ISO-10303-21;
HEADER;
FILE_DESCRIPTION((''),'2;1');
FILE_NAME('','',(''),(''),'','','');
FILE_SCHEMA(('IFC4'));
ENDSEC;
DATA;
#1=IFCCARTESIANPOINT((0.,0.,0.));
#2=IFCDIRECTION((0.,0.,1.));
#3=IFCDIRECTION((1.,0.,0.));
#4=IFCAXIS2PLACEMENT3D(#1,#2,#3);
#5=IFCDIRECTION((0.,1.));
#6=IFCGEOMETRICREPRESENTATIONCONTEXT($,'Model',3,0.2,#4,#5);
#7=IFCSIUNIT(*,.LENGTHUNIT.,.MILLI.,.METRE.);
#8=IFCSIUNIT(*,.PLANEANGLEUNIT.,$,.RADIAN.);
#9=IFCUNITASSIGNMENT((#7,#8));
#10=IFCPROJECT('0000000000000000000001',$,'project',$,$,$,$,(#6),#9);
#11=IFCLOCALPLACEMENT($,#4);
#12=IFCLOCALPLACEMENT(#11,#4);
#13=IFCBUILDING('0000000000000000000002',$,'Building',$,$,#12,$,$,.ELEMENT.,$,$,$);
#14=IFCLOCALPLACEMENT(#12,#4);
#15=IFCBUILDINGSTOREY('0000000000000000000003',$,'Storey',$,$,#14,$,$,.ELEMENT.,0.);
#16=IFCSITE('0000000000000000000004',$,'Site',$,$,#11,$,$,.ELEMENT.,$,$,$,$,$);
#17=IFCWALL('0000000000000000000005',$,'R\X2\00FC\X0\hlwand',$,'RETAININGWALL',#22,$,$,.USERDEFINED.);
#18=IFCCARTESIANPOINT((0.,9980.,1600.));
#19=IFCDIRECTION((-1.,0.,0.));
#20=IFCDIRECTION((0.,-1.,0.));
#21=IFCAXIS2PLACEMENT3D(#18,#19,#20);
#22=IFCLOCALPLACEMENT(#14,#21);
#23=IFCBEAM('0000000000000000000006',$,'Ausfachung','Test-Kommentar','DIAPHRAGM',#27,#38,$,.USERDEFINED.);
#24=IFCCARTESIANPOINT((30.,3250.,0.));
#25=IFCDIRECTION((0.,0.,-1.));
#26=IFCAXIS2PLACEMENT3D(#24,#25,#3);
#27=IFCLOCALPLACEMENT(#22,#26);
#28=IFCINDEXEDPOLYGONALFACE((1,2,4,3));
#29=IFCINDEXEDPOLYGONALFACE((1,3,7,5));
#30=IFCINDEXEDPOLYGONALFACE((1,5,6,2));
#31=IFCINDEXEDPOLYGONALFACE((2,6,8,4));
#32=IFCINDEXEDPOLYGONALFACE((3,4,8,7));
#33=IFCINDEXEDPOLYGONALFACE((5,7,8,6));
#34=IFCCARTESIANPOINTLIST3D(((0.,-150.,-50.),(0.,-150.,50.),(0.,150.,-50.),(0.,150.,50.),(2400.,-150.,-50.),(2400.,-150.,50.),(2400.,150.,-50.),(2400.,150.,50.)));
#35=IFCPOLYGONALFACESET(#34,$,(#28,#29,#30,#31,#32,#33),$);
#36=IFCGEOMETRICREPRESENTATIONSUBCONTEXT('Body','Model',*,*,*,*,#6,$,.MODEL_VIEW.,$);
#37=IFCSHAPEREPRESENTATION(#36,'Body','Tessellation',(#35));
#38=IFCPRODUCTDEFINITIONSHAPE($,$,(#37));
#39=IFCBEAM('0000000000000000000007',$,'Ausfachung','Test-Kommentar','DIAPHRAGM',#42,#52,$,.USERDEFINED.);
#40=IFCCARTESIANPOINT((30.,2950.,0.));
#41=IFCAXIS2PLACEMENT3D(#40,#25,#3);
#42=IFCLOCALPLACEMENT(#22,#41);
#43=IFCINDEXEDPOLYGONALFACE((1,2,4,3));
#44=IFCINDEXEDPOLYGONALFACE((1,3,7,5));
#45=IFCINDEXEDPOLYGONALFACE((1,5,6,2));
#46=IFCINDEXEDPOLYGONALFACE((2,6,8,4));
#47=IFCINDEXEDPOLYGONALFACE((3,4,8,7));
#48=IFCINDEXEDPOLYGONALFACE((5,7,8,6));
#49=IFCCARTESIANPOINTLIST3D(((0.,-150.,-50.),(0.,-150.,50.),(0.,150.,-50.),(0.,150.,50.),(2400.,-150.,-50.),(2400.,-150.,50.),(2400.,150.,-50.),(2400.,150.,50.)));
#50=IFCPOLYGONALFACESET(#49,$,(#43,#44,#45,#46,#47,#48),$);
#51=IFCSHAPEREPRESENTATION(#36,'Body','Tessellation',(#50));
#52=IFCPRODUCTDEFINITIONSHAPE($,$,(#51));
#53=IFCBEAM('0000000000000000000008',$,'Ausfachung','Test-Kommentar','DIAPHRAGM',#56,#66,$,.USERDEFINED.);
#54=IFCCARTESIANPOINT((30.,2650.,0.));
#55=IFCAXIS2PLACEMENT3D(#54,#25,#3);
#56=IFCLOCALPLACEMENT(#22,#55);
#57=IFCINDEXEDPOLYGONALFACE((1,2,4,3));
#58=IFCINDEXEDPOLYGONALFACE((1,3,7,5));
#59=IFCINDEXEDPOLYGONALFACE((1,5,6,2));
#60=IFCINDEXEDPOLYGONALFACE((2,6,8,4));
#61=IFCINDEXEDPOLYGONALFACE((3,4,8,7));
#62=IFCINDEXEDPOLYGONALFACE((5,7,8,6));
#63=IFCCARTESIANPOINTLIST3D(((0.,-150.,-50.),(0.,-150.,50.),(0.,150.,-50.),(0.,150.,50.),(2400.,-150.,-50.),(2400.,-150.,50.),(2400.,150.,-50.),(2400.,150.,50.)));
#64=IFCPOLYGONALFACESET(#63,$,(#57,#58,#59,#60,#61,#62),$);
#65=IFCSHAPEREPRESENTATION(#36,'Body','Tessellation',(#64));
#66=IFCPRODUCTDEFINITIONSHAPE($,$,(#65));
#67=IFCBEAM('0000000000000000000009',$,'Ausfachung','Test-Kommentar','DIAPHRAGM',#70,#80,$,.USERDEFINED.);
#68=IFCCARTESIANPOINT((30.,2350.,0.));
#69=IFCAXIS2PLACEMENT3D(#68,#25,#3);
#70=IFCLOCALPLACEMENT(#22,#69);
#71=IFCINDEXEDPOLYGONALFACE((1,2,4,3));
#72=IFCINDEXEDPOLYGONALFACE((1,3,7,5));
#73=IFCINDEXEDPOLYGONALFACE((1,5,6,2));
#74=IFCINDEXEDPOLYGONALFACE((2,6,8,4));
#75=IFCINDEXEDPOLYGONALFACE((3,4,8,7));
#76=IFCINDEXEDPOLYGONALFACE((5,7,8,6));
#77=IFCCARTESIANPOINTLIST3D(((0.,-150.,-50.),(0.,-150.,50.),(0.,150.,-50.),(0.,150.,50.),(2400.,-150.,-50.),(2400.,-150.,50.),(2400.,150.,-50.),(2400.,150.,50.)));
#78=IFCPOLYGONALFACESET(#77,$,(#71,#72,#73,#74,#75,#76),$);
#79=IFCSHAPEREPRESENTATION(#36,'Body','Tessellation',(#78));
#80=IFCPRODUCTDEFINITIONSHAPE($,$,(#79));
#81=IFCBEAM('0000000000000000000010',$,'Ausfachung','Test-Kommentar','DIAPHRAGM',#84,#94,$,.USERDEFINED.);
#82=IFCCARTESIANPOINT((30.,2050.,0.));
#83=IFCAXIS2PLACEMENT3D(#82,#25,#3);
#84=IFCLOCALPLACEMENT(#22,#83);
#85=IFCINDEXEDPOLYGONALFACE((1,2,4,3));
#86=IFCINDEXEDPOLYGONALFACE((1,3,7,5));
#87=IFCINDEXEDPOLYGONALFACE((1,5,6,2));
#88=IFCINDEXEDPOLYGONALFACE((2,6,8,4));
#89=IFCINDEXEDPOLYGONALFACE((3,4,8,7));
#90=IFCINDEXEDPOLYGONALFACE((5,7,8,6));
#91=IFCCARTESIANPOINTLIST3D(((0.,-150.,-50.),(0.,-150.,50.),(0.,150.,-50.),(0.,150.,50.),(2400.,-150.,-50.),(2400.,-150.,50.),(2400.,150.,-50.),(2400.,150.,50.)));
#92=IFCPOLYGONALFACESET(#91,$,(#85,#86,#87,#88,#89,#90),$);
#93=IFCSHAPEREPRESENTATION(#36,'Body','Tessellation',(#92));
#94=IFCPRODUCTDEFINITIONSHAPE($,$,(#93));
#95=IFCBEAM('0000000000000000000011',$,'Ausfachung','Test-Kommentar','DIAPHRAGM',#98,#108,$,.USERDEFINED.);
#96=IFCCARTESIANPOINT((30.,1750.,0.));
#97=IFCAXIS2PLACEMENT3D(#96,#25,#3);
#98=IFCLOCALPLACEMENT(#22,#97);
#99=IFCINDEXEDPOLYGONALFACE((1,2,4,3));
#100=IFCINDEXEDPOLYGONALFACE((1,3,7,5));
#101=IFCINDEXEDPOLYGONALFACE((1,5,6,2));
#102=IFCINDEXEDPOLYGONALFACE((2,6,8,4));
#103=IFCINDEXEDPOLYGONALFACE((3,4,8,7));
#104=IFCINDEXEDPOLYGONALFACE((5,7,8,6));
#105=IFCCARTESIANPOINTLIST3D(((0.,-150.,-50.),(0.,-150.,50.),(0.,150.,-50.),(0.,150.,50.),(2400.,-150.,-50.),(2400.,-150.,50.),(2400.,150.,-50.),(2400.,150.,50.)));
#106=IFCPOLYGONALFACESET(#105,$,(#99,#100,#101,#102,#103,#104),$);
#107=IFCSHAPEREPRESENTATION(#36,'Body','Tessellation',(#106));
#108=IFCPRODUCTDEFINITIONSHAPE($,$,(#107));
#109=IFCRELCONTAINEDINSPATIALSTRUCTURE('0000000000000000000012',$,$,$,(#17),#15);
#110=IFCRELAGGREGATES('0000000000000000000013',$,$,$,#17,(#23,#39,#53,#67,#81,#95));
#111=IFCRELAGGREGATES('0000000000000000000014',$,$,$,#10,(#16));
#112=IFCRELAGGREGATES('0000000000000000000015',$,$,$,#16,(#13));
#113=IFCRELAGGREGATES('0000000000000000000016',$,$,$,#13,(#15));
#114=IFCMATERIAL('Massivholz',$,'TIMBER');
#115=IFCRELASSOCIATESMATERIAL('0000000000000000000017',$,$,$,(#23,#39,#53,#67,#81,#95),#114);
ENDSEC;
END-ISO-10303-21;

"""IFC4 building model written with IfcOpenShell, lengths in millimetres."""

from ifc_helpers import new_model, si_unit, direction, frame, origin_with_axes, place, context, subcontext, project, spatial, line, indexed_curve, outline, extrude, material, element, aggregate, save


model = new_model("IFC4")

# Units and contexts
model_context = context("Model", 3, precision=0.2, world=origin_with_axes(), true_north=direction((0.0, 1.0)))
body_context = subcontext(model_context, "Body", "Model", "MODEL_VIEW")
ifc_project = project(units=[si_unit("LENGTHUNIT", "METRE", prefix="MILLI"), si_unit("PLANEANGLEUNIT", "RADIAN")], contexts=[model_context])

# Site, building, storey
site_placement = place(None, origin_with_axes())
site = spatial("IfcSite", under=ifc_project, at=site_placement, Name="Site", CompositionType="ELEMENT")
building_placement = place(site_placement, origin_with_axes())
building = spatial("IfcBuilding", under=site, at=building_placement, Name="Building", CompositionType="ELEMENT")
storey_placement = place(building_placement, origin_with_axes())
storey = spatial("IfcBuildingStorey", under=building, at=storey_placement, Name="Storey", CompositionType="ELEMENT", Elevation=0.0)

# Wall, beams
wall_placement = place(storey_placement, frame((0.0, 9980.0, 1600.0), z_axis=(-1.0, 0.0, 0.0), x_axis=(0.0, -1.0, 0.0)))
wall = element("IfcWall", 1, at=wall_placement, inside=storey, Name="Rühlwand", ObjectType="RETAININGWALL", PredefinedType="USERDEFINED")
ifc_material_1 = material(Name="Massivholz", Category="TIMBER")
beam_1_placement = place(wall_placement, frame((30.0, 3250.0, 0.0), z_axis=(0.0, 0.0, -1.0), x_axis=(1.0, 0.0, 0.0)))
beam_1 = element("IfcBeam", 2, at=beam_1_placement, material=ifc_material_1, Name="Ausfachung", Description="Test-Kommentar", ObjectType="DIAPHRAGM", PredefinedType="USERDEFINED", context=body_context, shape_type="SolidModel", body=[
    extrude(outline(indexed_curve([(-50.0, -150.0), (50.0, -150.0), (50.0, 150.0), (-50.0, 150.0)], segments=[line(1, 2, 3, 4, 1)])), frame((0.0, 0.0, 0.0), z_axis=(-1.0, 0.0, 0.0), x_axis=(0.0, 0.0, 1.0)), (0.0, 0.0, -1.0), 2400.0),
])
beam_2_placement = place(wall_placement, frame((30.0, 2950.0, 0.0), z_axis=(0.0, 0.0, -1.0), x_axis=(1.0, 0.0, 0.0)))
beam_2 = element("IfcBeam", 3, at=beam_2_placement, material=ifc_material_1, Name="Ausfachung", Description="Test-Kommentar", ObjectType="DIAPHRAGM", PredefinedType="USERDEFINED", context=body_context, shape_type="SolidModel", body=[
    extrude(outline(indexed_curve([(-50.0, -150.0), (50.0, -150.0), (50.0, 150.0), (-50.0, 150.0)], segments=[line(1, 2, 3, 4, 1)])), frame((0.0, 0.0, 0.0), z_axis=(-1.0, 0.0, 0.0), x_axis=(0.0, 0.0, 1.0)), (0.0, 0.0, -1.0), 2400.0),
])
beam_3_placement = place(wall_placement, frame((30.0, 2650.0, 0.0), z_axis=(0.0, 0.0, -1.0), x_axis=(1.0, 0.0, 0.0)))
beam_3 = element("IfcBeam", 4, at=beam_3_placement, material=ifc_material_1, Name="Ausfachung", Description="Test-Kommentar", ObjectType="DIAPHRAGM", PredefinedType="USERDEFINED", context=body_context, shape_type="SolidModel", body=[
    extrude(outline(indexed_curve([(-50.0, -150.0), (50.0, -150.0), (50.0, 150.0), (-50.0, 150.0)], segments=[line(1, 2, 3, 4, 1)])), frame((0.0, 0.0, 0.0), z_axis=(-1.0, 0.0, 0.0), x_axis=(0.0, 0.0, 1.0)), (0.0, 0.0, -1.0), 2400.0),
])
beam_4_placement = place(wall_placement, frame((30.0, 2350.0, 0.0), z_axis=(0.0, 0.0, -1.0), x_axis=(1.0, 0.0, 0.0)))
beam_4 = element("IfcBeam", 5, at=beam_4_placement, material=ifc_material_1, Name="Ausfachung", Description="Test-Kommentar", ObjectType="DIAPHRAGM", PredefinedType="USERDEFINED", context=body_context, shape_type="SolidModel", body=[
    extrude(outline(indexed_curve([(-50.0, -150.0), (50.0, -150.0), (50.0, 150.0), (-50.0, 150.0)], segments=[line(1, 2, 3, 4, 1)])), frame((0.0, 0.0, 0.0), z_axis=(-1.0, 0.0, 0.0), x_axis=(0.0, 0.0, 1.0)), (0.0, 0.0, -1.0), 2400.0),
])
beam_5_placement = place(wall_placement, frame((30.0, 2050.0, 0.0), z_axis=(0.0, 0.0, -1.0), x_axis=(1.0, 0.0, 0.0)))
beam_5 = element("IfcBeam", 6, at=beam_5_placement, material=ifc_material_1, Name="Ausfachung", Description="Test-Kommentar", ObjectType="DIAPHRAGM", PredefinedType="USERDEFINED", context=body_context, shape_type="SolidModel", body=[
    extrude(outline(indexed_curve([(-50.0, -150.0), (50.0, -150.0), (50.0, 150.0), (-50.0, 150.0)], segments=[line(1, 2, 3, 4, 1)])), frame((0.0, 0.0, 0.0), z_axis=(-1.0, 0.0, 0.0), x_axis=(0.0, 0.0, 1.0)), (0.0, 0.0, -1.0), 2400.0),
])
beam_6_placement = place(wall_placement, frame((30.0, 1750.0, 0.0), z_axis=(0.0, 0.0, -1.0), x_axis=(1.0, 0.0, 0.0)))
beam_6 = element("IfcBeam", 7, at=beam_6_placement, material=ifc_material_1, Name="Ausfachung", Description="Test-Kommentar", ObjectType="DIAPHRAGM", PredefinedType="USERDEFINED", context=body_context, shape_type="SolidModel", body=[
    extrude(outline(indexed_curve([(-50.0, -150.0), (50.0, -150.0), (50.0, 150.0), (-50.0, 150.0)], segments=[line(1, 2, 3, 4, 1)])), frame((0.0, 0.0, 0.0), z_axis=(-1.0, 0.0, 0.0), x_axis=(0.0, 0.0, 1.0)), (0.0, 0.0, -1.0), 2400.0),
])

aggregate(wall, [beam_1, beam_2, beam_3, beam_4, beam_5, beam_6])

save(model, "model.ifc")
